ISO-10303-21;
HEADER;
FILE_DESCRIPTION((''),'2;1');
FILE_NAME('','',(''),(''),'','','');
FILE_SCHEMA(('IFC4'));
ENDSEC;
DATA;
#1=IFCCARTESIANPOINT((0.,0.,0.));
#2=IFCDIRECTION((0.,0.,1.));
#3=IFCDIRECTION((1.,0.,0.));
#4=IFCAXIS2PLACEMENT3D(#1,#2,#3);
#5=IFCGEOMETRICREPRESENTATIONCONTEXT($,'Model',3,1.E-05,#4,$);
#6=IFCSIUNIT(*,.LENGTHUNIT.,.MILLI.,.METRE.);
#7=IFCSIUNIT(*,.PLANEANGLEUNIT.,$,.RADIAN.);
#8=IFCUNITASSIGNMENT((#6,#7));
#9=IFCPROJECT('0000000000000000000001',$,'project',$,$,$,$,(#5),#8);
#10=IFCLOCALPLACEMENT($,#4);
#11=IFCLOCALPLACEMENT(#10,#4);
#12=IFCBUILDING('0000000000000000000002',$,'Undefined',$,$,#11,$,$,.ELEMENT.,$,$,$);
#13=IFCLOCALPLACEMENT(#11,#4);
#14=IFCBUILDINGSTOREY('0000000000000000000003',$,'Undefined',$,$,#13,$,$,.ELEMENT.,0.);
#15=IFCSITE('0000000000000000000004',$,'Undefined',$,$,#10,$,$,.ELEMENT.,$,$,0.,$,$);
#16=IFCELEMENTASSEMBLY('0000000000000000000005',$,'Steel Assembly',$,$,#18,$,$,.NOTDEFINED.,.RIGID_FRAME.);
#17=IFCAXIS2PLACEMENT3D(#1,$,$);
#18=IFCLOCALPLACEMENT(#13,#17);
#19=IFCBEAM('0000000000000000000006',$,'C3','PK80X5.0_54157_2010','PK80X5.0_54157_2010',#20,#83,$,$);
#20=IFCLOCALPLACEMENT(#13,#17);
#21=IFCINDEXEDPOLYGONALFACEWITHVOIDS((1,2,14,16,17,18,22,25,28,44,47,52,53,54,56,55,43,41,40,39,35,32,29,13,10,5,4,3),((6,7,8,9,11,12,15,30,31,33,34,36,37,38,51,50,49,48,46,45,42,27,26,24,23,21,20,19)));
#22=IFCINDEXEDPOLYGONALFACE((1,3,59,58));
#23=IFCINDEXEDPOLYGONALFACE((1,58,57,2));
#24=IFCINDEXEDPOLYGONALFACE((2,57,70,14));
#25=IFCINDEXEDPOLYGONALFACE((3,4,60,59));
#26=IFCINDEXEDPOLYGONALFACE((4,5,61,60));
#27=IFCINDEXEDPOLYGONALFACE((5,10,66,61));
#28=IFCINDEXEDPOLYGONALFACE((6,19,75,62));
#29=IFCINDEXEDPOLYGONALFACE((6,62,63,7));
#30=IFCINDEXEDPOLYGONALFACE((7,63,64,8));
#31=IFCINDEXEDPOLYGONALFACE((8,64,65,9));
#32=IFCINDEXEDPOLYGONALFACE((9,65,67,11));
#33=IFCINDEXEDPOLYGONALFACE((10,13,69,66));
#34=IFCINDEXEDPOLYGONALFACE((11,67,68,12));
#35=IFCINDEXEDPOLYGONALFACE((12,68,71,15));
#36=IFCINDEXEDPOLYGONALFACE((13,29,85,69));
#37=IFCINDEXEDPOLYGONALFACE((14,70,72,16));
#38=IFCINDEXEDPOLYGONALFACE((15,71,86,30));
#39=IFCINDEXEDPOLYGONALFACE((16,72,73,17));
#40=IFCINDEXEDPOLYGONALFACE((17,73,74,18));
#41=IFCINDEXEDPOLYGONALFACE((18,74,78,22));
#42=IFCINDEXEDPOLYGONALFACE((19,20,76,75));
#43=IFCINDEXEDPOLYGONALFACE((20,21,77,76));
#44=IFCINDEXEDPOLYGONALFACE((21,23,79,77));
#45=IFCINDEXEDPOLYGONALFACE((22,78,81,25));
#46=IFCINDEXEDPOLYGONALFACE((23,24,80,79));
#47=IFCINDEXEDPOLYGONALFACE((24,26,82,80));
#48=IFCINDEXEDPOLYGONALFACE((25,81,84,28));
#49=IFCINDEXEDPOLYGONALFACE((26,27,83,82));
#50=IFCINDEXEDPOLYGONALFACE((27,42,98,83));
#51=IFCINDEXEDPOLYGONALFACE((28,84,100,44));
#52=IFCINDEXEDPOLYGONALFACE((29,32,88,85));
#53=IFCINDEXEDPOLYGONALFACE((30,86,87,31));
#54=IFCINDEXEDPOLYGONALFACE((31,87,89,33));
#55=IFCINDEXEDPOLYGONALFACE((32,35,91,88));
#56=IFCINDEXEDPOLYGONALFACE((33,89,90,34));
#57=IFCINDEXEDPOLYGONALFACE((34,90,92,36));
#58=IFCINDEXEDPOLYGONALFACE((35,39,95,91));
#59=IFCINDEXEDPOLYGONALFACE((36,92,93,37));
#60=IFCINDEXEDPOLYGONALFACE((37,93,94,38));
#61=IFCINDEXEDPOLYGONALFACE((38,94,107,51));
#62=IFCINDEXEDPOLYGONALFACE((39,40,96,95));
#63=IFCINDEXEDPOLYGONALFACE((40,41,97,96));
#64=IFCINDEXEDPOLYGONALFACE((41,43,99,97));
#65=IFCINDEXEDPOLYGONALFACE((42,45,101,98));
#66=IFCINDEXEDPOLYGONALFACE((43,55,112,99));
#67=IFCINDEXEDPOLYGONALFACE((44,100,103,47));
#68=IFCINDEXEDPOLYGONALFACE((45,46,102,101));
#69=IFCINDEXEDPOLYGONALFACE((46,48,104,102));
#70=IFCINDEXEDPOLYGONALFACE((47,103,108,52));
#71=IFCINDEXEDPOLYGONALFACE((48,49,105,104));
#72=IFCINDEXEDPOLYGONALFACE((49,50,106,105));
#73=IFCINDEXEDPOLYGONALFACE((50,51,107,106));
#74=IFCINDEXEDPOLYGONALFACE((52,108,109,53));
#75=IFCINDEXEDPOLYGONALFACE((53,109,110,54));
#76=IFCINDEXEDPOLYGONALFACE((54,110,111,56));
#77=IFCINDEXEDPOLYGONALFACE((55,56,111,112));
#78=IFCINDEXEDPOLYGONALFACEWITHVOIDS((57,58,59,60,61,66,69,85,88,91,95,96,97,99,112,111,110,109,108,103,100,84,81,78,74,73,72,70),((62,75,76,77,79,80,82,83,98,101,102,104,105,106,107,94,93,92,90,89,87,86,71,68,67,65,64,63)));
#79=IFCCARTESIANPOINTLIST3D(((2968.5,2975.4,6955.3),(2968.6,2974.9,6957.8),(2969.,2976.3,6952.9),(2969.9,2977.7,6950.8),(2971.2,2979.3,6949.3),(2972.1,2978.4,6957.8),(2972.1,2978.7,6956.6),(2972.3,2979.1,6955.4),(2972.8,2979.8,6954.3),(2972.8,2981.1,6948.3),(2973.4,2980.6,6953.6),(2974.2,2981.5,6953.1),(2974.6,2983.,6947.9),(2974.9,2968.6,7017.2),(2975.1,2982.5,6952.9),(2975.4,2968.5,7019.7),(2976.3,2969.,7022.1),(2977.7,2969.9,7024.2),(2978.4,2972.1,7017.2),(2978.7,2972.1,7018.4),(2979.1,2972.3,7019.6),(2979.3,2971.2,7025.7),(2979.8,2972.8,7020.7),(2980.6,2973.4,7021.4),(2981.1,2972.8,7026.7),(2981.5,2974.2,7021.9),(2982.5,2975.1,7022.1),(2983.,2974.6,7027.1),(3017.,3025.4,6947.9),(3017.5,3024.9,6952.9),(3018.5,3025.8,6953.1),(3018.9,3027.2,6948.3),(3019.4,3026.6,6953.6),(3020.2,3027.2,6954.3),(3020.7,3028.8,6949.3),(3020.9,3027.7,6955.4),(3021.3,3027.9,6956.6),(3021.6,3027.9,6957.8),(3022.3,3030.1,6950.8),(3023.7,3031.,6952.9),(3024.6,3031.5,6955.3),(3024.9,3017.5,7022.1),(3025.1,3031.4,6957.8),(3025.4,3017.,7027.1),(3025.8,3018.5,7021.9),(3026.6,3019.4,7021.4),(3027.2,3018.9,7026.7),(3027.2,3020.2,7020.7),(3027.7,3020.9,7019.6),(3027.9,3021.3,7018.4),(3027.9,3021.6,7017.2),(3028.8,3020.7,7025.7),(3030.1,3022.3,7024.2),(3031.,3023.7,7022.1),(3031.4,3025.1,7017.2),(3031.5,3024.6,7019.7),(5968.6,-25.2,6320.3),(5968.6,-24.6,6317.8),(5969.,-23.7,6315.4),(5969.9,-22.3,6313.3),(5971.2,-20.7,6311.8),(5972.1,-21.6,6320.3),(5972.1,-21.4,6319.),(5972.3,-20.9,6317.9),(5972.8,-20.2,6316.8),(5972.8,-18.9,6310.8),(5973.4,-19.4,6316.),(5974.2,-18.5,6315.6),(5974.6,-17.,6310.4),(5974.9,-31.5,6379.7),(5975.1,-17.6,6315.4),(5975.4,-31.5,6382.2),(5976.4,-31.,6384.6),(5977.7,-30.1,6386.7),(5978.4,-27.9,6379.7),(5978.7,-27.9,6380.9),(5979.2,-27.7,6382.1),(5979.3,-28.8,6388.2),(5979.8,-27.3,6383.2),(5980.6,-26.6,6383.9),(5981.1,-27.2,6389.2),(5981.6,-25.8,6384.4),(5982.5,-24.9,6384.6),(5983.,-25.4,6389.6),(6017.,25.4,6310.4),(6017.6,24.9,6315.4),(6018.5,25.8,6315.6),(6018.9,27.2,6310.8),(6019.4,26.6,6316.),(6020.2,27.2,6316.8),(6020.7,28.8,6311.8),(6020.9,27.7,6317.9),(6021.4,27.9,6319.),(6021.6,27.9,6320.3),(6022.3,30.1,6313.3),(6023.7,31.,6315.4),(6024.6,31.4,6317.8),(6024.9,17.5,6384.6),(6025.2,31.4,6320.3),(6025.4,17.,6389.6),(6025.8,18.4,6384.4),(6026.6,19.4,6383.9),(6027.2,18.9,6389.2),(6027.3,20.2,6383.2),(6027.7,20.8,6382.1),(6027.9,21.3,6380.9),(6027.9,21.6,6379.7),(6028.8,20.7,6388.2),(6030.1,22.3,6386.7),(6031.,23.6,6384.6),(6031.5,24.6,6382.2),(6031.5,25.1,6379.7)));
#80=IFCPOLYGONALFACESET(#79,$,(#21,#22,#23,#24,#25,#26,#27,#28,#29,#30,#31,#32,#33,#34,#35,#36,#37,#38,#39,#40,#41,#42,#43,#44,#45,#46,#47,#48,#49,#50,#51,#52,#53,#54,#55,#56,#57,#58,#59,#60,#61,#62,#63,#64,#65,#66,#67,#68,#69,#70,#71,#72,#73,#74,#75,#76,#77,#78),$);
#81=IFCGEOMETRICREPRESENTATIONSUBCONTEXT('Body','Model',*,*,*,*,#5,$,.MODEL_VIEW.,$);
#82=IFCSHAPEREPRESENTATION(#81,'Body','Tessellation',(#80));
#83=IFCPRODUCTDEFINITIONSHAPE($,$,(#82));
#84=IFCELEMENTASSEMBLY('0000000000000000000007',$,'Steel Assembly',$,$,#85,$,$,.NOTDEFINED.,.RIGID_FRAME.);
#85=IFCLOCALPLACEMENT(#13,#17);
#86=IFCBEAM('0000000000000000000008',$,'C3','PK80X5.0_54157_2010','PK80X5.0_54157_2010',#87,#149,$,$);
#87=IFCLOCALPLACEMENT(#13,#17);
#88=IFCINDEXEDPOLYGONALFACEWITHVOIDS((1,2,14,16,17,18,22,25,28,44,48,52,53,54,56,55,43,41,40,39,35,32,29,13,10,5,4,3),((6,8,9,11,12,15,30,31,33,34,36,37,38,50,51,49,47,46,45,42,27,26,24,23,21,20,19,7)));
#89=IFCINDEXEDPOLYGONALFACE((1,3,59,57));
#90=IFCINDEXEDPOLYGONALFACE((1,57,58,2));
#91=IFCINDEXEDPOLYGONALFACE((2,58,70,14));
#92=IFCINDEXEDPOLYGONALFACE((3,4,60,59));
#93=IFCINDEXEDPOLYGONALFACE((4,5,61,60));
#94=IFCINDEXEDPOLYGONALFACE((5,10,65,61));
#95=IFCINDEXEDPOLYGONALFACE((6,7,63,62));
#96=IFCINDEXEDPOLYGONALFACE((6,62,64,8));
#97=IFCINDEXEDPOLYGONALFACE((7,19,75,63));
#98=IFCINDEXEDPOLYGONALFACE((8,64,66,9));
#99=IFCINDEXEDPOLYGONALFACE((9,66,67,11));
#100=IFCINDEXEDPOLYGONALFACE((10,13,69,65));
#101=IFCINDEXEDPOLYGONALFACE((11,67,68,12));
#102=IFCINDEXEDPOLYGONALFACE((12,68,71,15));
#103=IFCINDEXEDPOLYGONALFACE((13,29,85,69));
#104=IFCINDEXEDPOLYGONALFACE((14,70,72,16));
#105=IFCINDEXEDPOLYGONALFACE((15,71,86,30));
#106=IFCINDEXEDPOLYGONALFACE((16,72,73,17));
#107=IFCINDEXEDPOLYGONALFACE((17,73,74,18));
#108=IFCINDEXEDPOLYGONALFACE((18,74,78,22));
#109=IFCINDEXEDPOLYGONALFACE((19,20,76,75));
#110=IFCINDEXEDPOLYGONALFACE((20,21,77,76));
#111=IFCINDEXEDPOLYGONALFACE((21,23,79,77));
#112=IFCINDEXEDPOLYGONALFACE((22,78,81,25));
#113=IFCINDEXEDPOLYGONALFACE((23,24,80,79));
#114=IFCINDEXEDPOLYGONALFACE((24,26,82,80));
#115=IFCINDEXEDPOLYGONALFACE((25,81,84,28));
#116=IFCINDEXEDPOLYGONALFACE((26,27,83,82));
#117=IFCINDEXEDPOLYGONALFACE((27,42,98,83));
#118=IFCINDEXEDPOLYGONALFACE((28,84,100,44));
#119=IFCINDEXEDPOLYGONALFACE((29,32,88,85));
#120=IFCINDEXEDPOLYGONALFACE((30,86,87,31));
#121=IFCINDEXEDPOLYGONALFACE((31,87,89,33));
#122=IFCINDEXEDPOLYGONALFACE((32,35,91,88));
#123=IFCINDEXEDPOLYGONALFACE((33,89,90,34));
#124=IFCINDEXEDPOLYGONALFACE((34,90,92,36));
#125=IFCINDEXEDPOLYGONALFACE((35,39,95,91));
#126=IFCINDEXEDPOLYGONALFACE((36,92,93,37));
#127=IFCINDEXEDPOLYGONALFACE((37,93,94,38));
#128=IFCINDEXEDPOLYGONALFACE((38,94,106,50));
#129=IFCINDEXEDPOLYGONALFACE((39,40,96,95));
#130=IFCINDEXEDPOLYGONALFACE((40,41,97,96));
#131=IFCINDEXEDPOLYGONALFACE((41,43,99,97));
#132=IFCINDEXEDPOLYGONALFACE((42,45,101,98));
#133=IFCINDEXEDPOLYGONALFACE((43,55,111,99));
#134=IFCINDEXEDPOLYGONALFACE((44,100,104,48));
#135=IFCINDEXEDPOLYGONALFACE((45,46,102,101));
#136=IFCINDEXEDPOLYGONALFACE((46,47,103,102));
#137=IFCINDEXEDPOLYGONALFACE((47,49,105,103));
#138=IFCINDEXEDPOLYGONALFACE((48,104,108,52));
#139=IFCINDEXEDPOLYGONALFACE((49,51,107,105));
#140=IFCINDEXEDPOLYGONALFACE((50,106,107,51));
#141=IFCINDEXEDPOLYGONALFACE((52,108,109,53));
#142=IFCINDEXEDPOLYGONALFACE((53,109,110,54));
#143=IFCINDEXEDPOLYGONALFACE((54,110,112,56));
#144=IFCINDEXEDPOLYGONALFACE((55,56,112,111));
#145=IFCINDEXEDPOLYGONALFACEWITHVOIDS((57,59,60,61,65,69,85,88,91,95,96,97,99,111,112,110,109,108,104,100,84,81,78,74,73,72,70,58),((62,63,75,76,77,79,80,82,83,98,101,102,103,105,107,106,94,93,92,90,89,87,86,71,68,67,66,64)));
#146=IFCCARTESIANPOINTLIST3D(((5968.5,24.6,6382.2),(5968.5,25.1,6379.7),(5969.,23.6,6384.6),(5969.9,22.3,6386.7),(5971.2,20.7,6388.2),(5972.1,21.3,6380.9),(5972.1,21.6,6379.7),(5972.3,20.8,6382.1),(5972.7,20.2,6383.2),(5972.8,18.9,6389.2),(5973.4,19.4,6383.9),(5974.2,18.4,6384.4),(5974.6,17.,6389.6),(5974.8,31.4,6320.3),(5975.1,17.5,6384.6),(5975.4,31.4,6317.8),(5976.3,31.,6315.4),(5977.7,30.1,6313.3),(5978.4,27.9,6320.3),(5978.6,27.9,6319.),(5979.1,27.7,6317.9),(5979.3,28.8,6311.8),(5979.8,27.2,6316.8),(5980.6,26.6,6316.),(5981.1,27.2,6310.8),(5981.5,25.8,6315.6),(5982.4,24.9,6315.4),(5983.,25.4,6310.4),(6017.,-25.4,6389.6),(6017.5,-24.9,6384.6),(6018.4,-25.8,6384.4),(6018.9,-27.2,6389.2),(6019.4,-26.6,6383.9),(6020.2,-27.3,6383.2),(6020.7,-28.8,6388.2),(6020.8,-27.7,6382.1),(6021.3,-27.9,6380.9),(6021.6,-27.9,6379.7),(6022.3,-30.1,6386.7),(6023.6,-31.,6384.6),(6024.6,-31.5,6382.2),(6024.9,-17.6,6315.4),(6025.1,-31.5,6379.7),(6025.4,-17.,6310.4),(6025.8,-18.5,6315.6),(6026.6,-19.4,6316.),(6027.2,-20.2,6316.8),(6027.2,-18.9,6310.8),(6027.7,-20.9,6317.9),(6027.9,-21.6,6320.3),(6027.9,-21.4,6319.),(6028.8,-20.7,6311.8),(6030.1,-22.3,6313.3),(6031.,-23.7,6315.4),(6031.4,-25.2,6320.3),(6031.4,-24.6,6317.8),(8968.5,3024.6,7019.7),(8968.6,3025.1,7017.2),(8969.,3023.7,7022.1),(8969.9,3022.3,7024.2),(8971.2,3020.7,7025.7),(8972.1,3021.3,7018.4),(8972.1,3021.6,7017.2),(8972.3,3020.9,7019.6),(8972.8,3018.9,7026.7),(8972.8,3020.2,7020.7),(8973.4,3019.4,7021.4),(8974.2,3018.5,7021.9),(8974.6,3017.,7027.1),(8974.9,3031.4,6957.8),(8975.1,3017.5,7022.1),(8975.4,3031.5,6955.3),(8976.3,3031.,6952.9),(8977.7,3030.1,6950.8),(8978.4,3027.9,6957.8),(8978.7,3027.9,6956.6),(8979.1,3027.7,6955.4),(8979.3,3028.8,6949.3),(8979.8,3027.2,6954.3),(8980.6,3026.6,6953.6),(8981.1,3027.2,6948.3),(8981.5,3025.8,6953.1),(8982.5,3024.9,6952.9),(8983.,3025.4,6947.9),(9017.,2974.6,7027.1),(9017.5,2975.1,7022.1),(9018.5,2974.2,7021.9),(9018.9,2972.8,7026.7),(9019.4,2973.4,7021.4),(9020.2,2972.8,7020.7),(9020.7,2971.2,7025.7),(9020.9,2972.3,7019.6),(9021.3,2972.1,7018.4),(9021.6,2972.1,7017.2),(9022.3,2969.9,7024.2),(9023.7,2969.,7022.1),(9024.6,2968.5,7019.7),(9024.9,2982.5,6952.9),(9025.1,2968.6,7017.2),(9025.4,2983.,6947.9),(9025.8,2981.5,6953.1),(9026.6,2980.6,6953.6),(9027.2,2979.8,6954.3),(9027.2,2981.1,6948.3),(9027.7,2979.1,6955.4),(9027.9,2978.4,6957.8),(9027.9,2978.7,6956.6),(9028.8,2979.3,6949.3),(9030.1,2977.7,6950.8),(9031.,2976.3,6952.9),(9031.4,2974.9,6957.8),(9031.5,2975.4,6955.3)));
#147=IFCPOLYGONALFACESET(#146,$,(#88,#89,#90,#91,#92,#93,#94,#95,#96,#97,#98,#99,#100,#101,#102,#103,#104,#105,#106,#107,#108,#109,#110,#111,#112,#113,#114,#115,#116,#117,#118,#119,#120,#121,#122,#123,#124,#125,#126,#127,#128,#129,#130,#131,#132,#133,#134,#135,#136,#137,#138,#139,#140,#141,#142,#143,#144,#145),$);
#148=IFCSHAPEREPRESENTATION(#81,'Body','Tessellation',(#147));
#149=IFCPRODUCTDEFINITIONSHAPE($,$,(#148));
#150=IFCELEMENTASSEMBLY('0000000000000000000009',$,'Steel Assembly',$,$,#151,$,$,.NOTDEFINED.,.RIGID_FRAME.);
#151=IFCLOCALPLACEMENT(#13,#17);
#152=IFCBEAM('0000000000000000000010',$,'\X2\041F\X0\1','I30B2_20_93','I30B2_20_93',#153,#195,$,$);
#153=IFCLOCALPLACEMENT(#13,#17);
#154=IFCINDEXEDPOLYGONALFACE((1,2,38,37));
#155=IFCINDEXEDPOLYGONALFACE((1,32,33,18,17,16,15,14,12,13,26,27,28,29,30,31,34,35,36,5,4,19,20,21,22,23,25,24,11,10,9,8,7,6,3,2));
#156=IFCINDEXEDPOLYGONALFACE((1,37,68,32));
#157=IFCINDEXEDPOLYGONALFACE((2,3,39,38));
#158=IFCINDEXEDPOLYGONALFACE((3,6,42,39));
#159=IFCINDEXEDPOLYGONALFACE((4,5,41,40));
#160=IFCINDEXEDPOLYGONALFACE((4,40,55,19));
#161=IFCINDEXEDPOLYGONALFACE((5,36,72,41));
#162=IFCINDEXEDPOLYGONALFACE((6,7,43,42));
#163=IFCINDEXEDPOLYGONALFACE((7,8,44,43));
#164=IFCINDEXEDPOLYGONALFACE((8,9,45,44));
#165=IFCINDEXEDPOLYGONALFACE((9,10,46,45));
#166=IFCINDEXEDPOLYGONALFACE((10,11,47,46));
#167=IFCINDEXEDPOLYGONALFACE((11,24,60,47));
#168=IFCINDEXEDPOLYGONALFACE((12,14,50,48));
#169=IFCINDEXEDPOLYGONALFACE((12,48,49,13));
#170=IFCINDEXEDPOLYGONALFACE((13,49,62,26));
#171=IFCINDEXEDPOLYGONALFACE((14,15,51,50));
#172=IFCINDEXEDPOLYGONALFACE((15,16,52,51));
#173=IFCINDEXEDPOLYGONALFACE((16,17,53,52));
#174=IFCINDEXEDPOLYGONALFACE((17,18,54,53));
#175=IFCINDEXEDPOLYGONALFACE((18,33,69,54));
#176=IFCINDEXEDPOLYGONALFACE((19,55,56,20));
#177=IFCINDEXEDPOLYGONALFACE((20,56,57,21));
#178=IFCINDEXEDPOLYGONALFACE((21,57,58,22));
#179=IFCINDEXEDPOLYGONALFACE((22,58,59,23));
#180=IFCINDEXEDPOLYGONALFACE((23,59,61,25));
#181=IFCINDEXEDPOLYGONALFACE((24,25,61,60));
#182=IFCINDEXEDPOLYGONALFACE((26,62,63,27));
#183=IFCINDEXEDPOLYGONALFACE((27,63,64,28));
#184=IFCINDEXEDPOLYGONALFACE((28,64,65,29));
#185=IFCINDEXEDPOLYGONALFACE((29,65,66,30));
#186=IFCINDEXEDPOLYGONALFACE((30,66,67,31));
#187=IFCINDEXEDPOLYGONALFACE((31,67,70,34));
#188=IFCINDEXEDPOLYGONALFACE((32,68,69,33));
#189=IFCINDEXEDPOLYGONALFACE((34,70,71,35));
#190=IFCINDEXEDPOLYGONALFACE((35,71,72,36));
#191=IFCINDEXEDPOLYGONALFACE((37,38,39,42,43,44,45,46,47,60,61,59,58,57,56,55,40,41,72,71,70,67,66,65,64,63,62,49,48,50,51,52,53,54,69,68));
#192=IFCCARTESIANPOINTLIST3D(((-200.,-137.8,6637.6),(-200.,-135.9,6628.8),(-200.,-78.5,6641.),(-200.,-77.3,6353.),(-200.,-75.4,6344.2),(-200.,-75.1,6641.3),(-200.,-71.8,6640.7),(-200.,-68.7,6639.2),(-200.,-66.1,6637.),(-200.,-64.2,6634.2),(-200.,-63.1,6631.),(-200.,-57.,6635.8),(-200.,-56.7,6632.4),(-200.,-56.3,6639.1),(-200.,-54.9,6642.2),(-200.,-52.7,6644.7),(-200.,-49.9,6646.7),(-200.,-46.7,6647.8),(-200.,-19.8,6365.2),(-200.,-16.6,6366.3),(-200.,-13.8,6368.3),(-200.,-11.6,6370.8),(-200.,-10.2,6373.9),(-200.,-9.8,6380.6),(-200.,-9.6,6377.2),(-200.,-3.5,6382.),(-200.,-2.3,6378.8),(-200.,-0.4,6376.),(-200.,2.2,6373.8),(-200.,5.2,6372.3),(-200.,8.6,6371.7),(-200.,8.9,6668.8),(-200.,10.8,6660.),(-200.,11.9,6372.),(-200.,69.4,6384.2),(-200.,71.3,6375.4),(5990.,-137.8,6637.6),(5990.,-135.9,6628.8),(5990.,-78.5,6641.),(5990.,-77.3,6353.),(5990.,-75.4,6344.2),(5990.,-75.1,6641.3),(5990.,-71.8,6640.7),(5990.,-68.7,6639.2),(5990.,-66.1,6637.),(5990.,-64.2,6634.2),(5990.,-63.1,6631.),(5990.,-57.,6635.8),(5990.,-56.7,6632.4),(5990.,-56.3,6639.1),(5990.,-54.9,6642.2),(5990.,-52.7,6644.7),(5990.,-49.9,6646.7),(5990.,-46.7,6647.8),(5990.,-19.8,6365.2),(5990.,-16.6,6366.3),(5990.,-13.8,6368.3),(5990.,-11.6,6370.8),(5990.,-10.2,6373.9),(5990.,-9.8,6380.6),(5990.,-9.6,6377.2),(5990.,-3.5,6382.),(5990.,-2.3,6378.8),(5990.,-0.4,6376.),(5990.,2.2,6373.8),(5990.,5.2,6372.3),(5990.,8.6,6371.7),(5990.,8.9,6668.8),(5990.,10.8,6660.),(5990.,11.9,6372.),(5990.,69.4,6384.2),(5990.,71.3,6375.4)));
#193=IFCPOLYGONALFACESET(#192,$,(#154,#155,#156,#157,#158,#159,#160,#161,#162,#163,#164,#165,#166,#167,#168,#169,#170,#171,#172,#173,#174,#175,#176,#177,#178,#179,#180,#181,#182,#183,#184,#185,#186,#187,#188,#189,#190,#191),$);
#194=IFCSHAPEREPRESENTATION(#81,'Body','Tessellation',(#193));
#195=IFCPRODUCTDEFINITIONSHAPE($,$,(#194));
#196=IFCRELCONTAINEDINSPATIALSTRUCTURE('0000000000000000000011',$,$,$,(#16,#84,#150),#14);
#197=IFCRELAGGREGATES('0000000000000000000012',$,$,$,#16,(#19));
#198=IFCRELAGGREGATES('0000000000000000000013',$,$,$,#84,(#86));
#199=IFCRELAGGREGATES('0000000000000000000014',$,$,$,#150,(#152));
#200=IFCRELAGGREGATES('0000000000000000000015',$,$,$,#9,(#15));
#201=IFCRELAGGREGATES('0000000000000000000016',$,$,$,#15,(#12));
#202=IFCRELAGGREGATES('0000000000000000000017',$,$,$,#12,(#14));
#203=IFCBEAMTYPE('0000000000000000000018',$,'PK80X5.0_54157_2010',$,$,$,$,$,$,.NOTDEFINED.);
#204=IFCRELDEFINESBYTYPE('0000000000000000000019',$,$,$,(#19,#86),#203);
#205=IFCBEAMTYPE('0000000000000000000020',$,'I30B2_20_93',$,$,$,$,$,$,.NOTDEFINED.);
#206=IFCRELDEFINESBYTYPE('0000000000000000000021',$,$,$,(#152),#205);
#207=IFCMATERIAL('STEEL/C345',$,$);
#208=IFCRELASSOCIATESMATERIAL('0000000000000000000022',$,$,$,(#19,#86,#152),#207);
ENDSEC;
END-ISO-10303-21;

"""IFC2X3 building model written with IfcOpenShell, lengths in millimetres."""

from ifc_helpers import new_model, si_unit, frame, origin_with_axes, origin_2d_with_axis, place, context, subcontext, project, spatial, hollow_rectangle, i_section, extrude, material, type_object, element, aggregate, save


model = new_model("IFC2X3")

# Units and contexts
model_context = context("Model", 3, precision=1e-05, world=origin_with_axes())
body_context = subcontext(model_context, "Body", "Model", "MODEL_VIEW")
ifc_project = project(units=[si_unit("LENGTHUNIT", "METRE", prefix="MILLI"), si_unit("PLANEANGLEUNIT", "RADIAN")], contexts=[model_context])

# Site, building, storey
site_placement = place(None, origin_with_axes())
site = spatial("IfcSite", under=ifc_project, at=site_placement, Name="Undefined", CompositionType="ELEMENT", RefElevation=0.0)
building_placement = place(site_placement, origin_with_axes())
building = spatial("IfcBuilding", under=site, at=building_placement, Name="Undefined", CompositionType="ELEMENT")
storey_placement = place(building_placement, origin_with_axes())
storey = spatial("IfcBuildingStorey", under=building, at=storey_placement, Name="Undefined", CompositionType="ELEMENT", Elevation=0.0)

# Shared definitions
ifc_material_1 = material(Name="STEEL/C345")

# Element assemblies, beams
assembly_1_placement = place(storey_placement, origin_with_axes())
assembly_1 = element("IfcElementAssembly", 1, at=assembly_1_placement, inside=storey, Name="Steel Assembly", AssemblyPlace="NOTDEFINED", PredefinedType="RIGID_FRAME")
beam_type_1 = type_object("IfcBeamType", Name="PK80X5.0_54157_2010", PredefinedType="NOTDEFINED")
beam_1_placement = place(assembly_1_placement, frame((6000.0, 0.0, 6350.0), z_axis=(0.10507, -0.10507, 0.988899), x_axis=(-0.699257, 0.699257, 0.148592)))
beam_1 = element("IfcBeam", 2, at=beam_1_placement, type_object=beam_type_1, material=ifc_material_1, Name="C3", Description="PK80X5.0_54157_2010", ObjectType="PK80X5.0_54157_2010", context=body_context, shape_type="SweptSolid", body=[
    extrude(hollow_rectangle(XDim=80.0, YDim=80.0, WallThickness=5.0, InnerFilletRadius=5.0, OuterFilletRadius=10.0, at=origin_2d_with_axis()), frame((4290.3, 0.0, 0.0), z_axis=(-1.0, 0.0, 0.0), x_axis=(0.0, -1.0, 0.0)), (0.0, 0.0, 1.0), 4290.3),
])
aggregate(assembly_1, [beam_1])
assembly_2_placement = place(storey_placement, origin_with_axes())
assembly_2 = element("IfcElementAssembly", 3, at=assembly_2_placement, inside=storey, Name="Steel Assembly", AssemblyPlace="NOTDEFINED", PredefinedType="RIGID_FRAME")
beam_2_placement = place(assembly_2_placement, frame((6000.0, 0.0, 6350.0), z_axis=(-0.10507, -0.10507, 0.988899), x_axis=(0.699257, 0.699257, 0.148592)))
beam_2 = element("IfcBeam", 4, at=beam_2_placement, type_object=beam_type_1, material=ifc_material_1, Name="C3", Description="PK80X5.0_54157_2010", ObjectType="PK80X5.0_54157_2010", context=body_context, shape_type="SweptSolid", body=[
    extrude(hollow_rectangle(XDim=80.0, YDim=80.0, WallThickness=5.0, InnerFilletRadius=5.0, OuterFilletRadius=10.0, at=origin_2d_with_axis()), frame((4290.3, 0.0, 0.0), z_axis=(-1.0, 0.0, 0.0), x_axis=(0.0, -1.0, 0.0)), (0.0, 0.0, 1.0), 4290.3),
])
aggregate(assembly_2, [beam_2])
assembly_3_placement = place(storey_placement, origin_with_axes())
assembly_3 = element("IfcElementAssembly", 5, at=assembly_3_placement, inside=storey, Name="Steel Assembly", AssemblyPlace="NOTDEFINED", PredefinedType="RIGID_FRAME")
beam_type_2 = type_object("IfcBeamType", Name="I30B2_20_93", PredefinedType="NOTDEFINED")
beam_3_placement = place(assembly_3_placement, frame((5990.0, -33.3, 6506.5), z_axis=(0.0, 0.207912, -0.978148), x_axis=(-1.0, 0.0, 0.0)))
beam_3 = element("IfcBeam", 6, at=beam_3_placement, type_object=beam_type_2, material=ifc_material_1, Name="П1", Description="I30B2_20_93", ObjectType="I30B2_20_93", context=body_context, shape_type="SweptSolid", body=[
    extrude(i_section(OverallWidth=150.0, OverallDepth=300.0, WebThickness=6.5, FlangeThickness=9.0, FilletRadius=13.0, at=origin_2d_with_axis()), frame((6190.0, 0.0, 0.0), z_axis=(-1.0, 0.0, 0.0), x_axis=(0.0, -1.0, 0.0)), (0.0, 0.0, 1.0), 6190.0),
])
aggregate(assembly_3, [beam_3])

save(model, "model.ifc")
